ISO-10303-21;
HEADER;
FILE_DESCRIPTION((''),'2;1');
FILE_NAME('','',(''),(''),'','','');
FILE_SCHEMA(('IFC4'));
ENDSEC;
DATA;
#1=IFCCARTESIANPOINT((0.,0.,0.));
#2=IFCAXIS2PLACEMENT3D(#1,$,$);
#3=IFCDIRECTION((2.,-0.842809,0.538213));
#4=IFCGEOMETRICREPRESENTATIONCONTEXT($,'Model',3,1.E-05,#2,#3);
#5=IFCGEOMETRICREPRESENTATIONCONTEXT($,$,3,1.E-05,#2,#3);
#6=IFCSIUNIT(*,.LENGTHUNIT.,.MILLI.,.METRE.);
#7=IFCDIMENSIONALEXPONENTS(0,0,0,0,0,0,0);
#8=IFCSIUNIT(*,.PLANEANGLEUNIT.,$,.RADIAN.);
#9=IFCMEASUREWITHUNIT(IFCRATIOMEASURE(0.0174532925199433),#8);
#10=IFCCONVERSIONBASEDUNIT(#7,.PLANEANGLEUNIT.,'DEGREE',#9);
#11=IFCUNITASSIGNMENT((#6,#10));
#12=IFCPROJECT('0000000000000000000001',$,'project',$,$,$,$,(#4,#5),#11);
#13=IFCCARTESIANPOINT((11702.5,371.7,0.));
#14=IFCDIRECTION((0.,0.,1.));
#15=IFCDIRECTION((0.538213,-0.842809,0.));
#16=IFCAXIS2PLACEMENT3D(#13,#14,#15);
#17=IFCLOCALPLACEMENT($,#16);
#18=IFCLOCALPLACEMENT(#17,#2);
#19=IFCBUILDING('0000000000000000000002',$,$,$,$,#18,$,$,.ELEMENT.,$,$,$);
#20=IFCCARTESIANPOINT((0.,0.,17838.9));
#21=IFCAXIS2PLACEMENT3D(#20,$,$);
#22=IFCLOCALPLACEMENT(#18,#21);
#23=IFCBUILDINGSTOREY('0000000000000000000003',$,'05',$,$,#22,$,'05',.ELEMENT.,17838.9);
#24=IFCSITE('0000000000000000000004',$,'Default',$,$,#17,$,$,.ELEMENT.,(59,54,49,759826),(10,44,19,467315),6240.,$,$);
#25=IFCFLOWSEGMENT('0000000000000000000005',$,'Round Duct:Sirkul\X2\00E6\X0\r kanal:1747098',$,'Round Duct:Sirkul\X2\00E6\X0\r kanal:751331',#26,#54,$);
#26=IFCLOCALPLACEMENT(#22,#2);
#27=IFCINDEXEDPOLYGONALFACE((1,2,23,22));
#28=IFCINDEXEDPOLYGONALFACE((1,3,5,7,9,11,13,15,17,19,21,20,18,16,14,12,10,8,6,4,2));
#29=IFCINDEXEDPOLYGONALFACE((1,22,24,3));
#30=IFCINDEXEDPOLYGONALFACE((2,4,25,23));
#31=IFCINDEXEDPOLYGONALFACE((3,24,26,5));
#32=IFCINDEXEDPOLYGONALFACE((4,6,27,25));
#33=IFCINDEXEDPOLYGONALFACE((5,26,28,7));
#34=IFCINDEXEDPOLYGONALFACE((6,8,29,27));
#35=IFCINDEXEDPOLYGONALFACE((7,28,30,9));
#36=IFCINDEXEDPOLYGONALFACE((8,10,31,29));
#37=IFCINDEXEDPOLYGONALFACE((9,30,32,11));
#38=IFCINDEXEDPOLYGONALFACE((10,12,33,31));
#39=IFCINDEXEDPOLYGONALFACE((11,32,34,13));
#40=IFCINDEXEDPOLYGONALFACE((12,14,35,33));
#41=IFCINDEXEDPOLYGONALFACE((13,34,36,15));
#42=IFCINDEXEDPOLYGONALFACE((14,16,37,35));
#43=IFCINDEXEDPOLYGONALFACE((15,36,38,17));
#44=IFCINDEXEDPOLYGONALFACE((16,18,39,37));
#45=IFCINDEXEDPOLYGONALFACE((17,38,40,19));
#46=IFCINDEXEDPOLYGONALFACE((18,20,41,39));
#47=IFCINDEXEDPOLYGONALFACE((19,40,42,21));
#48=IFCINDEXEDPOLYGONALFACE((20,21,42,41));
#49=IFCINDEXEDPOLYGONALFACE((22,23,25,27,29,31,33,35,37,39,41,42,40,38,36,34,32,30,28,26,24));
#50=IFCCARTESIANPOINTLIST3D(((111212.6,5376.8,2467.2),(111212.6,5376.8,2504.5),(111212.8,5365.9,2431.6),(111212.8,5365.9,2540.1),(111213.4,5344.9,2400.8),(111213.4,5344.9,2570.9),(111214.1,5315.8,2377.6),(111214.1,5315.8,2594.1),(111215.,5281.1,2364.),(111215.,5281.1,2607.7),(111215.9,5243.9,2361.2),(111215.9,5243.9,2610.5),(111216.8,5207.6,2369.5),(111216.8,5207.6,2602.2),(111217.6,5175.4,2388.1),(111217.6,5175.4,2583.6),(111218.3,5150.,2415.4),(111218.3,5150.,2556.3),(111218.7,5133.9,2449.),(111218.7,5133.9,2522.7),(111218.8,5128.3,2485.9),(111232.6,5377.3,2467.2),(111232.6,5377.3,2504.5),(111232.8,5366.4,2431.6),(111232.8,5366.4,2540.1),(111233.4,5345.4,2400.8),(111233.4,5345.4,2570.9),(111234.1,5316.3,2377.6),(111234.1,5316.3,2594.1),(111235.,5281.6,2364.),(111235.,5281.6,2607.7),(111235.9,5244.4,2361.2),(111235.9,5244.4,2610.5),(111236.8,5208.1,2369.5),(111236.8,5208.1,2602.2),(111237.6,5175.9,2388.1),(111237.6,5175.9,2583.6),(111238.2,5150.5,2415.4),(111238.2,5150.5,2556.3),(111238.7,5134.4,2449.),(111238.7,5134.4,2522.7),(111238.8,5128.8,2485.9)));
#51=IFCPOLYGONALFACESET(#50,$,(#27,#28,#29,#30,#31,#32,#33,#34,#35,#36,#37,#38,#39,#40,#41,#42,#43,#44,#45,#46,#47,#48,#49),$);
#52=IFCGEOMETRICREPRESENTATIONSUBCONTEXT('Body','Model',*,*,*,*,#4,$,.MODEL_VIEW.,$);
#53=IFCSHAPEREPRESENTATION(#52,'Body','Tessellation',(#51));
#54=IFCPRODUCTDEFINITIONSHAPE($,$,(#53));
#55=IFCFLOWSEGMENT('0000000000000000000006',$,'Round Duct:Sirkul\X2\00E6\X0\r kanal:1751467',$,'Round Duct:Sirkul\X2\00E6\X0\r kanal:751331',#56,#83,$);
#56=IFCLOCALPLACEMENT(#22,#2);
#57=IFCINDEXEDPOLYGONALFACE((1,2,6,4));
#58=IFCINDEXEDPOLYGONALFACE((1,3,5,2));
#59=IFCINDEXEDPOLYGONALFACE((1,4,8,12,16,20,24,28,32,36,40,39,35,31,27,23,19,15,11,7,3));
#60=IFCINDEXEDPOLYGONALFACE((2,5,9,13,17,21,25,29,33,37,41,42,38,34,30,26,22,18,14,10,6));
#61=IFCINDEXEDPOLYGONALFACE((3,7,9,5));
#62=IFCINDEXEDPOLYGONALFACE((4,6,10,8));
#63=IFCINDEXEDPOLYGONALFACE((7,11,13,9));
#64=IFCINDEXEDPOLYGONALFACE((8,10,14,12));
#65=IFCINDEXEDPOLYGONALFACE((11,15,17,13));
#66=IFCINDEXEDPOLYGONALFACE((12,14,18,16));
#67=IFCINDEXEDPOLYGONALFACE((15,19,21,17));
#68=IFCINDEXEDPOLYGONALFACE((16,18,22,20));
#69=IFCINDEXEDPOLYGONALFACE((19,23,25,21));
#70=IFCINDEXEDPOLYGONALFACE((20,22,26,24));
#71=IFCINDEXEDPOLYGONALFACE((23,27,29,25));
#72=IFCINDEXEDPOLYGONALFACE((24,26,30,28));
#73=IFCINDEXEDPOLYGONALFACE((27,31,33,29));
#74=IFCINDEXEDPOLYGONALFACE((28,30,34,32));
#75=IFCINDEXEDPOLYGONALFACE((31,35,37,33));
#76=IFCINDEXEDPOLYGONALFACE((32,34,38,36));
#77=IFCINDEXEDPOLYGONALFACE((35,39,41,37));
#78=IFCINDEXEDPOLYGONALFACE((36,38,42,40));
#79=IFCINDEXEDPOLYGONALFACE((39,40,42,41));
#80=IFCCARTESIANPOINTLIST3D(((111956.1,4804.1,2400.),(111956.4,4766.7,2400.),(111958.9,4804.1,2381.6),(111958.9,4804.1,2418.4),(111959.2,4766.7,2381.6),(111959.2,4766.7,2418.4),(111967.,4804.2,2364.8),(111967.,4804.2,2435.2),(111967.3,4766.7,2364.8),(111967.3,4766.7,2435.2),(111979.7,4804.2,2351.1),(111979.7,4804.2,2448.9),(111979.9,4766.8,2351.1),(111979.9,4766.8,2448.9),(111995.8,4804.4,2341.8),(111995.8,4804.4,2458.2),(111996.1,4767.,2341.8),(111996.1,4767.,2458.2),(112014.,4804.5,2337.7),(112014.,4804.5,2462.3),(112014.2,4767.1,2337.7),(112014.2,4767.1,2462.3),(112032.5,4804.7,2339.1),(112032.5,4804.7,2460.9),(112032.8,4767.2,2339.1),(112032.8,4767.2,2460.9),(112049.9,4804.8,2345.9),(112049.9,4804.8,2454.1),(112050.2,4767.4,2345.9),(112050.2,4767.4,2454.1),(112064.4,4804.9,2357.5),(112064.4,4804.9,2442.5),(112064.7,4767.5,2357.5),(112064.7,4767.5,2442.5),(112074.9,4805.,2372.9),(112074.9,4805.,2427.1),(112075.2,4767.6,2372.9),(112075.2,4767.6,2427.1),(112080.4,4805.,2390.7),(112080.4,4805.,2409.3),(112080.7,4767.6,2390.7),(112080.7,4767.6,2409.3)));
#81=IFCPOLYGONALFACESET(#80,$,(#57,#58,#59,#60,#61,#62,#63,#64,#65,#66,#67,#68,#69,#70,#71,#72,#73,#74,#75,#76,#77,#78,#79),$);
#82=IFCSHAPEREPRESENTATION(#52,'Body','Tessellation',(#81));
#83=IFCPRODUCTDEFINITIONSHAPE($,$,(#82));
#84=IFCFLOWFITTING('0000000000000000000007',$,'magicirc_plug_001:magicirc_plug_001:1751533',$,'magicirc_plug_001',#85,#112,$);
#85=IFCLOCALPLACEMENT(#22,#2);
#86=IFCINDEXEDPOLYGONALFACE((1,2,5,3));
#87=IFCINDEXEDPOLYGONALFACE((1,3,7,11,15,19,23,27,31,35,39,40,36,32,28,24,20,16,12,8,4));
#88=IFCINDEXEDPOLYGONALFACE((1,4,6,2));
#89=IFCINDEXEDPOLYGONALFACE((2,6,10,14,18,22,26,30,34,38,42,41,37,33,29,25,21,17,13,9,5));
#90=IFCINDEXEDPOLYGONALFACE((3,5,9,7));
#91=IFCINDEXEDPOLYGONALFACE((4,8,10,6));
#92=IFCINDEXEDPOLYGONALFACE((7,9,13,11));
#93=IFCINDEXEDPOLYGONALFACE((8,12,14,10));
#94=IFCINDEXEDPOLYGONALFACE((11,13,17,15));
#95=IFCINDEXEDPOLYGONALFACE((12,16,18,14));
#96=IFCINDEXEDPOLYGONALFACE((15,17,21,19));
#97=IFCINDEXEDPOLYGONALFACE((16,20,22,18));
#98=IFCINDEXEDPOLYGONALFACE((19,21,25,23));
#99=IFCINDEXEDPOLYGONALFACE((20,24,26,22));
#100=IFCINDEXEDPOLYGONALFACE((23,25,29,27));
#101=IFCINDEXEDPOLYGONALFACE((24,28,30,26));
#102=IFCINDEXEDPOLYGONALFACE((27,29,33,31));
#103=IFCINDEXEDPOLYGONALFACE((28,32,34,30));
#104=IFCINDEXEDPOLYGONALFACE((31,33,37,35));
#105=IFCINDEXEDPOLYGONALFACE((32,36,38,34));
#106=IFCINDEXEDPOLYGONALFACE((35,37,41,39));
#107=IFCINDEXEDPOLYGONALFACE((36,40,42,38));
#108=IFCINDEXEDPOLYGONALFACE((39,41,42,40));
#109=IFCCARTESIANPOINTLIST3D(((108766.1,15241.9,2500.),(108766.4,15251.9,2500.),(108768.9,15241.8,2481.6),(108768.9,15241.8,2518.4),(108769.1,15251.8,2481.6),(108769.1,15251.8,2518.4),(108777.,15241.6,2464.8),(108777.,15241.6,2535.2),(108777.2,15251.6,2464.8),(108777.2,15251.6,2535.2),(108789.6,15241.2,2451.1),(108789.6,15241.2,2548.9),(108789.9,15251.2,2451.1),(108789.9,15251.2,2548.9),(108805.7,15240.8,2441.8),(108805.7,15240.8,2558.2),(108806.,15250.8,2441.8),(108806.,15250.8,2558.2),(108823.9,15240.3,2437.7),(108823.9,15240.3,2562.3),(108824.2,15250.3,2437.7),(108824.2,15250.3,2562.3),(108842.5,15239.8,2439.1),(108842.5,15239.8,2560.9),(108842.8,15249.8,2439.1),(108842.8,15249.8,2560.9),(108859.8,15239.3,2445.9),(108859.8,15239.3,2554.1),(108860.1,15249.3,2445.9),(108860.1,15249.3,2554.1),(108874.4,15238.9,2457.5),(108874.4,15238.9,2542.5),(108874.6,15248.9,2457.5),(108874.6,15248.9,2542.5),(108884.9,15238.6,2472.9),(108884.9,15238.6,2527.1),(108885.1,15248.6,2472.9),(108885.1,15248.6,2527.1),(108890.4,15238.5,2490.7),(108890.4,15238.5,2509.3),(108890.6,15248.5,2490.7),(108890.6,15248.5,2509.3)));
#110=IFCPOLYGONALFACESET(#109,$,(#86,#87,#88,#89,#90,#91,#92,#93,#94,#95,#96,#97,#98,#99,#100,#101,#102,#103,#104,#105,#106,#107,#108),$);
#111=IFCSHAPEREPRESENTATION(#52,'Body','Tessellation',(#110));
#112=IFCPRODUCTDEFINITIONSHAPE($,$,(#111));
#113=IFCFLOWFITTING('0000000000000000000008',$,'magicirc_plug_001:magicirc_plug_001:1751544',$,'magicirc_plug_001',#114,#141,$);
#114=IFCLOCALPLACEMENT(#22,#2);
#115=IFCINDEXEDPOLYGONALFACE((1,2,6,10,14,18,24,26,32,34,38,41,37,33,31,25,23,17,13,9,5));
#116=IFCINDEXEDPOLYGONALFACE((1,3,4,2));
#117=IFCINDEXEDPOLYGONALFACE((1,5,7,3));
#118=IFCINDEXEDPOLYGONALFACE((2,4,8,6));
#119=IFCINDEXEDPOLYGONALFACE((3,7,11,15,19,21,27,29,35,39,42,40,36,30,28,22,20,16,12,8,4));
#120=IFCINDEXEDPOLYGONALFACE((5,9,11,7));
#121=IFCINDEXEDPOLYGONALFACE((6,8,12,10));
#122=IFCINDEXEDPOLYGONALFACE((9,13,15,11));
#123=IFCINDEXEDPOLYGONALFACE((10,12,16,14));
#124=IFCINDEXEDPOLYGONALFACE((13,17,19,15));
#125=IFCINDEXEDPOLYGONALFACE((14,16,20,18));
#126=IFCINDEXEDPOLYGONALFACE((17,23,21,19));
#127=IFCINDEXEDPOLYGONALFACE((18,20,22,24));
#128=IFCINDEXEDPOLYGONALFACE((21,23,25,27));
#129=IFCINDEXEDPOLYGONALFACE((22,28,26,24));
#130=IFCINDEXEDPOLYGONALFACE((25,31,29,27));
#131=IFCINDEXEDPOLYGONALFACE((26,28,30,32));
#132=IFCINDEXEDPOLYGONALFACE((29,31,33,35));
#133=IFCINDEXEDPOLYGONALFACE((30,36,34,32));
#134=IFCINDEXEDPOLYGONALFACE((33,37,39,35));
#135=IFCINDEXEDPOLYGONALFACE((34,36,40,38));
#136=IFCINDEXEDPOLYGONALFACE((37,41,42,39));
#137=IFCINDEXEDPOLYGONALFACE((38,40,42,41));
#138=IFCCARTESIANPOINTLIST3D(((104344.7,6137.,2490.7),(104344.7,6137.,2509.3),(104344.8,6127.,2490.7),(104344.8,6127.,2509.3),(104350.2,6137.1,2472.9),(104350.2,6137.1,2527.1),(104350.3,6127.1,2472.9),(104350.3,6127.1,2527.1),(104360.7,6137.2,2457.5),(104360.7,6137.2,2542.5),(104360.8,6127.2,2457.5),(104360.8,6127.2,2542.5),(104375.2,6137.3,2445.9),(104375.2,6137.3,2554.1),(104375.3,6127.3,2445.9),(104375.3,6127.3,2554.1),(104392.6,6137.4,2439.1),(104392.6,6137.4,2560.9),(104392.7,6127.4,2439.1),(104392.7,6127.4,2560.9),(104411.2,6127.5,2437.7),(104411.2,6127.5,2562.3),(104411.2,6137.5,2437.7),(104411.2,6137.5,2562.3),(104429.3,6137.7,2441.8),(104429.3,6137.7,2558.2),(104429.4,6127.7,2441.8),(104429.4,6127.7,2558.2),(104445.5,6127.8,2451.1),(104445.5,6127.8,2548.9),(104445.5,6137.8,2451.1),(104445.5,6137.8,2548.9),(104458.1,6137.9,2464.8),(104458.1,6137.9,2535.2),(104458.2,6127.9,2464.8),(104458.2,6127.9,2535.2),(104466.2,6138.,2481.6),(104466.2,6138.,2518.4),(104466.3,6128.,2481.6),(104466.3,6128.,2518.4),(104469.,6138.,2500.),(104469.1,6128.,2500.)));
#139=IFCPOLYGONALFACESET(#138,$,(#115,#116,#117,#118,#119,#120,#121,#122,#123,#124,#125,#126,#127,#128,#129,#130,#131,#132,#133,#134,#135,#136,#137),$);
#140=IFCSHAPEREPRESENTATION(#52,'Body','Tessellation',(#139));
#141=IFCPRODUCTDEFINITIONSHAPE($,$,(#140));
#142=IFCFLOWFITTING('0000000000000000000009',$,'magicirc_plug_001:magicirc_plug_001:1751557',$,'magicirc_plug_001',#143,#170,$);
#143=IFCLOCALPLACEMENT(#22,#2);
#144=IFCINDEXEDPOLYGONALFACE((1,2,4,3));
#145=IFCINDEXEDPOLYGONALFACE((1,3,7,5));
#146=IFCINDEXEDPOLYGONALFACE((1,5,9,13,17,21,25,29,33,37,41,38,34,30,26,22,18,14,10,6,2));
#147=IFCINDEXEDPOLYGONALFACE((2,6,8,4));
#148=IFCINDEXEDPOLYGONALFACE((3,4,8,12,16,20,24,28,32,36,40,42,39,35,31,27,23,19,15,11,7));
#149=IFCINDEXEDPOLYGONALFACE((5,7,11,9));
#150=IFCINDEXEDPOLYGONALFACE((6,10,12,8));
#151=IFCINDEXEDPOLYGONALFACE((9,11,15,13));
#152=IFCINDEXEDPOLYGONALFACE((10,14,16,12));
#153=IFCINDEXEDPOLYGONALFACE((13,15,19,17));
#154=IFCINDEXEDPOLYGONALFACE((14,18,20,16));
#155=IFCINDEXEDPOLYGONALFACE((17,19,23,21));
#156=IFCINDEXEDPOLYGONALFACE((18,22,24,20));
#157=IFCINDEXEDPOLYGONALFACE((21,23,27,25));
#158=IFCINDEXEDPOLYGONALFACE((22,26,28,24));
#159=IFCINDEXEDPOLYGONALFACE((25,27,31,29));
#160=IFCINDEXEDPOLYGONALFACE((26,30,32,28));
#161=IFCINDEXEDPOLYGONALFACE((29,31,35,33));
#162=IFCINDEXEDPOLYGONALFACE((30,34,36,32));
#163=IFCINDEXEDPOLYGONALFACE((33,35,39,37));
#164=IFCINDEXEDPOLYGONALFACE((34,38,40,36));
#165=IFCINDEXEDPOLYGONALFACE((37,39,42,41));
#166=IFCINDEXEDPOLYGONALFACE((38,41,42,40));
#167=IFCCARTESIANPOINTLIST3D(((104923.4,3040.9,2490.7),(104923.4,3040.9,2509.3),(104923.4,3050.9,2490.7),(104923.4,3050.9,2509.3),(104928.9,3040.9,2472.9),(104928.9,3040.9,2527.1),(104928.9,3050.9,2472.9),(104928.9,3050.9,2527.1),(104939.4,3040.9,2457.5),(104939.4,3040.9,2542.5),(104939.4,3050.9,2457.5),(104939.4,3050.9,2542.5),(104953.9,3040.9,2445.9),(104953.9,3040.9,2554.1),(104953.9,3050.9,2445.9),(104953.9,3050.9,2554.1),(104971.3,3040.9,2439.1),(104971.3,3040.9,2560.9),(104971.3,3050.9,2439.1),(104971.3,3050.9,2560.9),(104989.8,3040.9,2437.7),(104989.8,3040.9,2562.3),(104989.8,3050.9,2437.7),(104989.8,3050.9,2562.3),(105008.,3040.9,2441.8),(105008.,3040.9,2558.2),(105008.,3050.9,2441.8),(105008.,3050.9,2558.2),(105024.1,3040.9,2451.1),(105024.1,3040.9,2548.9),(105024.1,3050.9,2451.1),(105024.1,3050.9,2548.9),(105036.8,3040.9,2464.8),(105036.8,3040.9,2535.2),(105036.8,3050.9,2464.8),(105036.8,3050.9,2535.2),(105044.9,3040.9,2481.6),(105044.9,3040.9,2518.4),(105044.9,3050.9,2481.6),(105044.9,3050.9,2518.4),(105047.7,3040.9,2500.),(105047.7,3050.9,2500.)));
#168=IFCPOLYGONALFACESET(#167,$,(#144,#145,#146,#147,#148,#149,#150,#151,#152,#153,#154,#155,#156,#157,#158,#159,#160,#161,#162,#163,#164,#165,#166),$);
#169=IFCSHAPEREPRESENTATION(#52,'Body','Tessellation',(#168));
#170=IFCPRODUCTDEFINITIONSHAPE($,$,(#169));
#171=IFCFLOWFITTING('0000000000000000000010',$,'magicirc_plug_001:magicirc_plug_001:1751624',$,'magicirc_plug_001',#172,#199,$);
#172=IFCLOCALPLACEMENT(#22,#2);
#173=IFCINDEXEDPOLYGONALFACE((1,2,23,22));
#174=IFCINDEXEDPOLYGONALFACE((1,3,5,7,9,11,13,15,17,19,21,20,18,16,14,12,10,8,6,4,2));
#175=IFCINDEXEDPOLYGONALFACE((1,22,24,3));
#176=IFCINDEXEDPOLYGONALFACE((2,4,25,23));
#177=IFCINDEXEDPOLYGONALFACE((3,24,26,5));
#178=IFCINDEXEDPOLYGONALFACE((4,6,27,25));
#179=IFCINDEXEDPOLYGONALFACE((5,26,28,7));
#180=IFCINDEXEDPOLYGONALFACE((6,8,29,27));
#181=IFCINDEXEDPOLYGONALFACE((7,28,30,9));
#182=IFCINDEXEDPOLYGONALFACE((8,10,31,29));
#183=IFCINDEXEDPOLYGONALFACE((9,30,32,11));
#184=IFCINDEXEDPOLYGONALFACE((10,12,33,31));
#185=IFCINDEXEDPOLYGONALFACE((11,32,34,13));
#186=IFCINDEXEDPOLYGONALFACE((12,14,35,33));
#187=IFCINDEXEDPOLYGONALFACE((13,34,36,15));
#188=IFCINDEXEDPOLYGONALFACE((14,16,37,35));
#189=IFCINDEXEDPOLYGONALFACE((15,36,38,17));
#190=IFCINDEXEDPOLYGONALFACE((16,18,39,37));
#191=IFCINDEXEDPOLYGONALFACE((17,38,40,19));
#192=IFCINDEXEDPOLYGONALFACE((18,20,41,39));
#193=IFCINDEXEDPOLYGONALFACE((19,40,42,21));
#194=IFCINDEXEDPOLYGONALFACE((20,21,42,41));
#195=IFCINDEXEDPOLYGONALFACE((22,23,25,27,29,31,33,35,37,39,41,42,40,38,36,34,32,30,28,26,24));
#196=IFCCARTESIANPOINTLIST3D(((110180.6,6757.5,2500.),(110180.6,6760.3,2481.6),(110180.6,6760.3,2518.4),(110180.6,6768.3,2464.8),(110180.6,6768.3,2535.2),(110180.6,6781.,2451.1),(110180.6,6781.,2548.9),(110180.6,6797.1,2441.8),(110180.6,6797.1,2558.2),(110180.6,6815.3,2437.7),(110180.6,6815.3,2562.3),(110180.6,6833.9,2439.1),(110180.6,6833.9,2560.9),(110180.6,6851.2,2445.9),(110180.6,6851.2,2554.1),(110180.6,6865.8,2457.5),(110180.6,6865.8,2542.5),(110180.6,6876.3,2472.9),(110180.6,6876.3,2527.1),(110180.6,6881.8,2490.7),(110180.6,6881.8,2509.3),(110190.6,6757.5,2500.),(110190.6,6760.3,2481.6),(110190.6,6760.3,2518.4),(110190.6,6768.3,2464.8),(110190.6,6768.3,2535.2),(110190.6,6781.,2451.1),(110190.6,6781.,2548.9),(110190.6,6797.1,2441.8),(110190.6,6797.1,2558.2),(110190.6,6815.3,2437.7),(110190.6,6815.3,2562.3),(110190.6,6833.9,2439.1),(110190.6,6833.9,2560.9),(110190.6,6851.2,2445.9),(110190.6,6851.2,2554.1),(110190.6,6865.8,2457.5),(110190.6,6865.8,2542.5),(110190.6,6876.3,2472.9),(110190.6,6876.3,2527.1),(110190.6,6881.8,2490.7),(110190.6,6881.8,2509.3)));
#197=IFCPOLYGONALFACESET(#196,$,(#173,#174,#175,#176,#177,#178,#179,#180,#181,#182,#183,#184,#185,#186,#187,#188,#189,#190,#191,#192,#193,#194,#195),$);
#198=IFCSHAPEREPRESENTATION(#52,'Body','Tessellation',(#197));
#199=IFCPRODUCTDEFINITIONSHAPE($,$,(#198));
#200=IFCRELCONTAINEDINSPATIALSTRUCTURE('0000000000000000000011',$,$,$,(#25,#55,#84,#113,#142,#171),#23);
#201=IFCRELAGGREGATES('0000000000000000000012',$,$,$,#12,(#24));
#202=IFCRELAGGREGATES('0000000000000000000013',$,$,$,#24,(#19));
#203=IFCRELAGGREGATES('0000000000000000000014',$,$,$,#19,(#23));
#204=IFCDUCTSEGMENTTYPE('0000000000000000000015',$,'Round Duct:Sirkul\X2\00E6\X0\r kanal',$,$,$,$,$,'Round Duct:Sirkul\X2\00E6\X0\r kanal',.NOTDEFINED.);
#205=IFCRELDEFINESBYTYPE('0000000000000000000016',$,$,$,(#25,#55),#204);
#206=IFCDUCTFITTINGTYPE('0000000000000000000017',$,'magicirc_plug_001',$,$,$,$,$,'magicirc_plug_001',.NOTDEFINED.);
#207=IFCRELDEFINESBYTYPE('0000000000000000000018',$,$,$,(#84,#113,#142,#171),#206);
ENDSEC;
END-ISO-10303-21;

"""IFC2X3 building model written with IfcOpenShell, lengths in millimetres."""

from ifc_helpers import new_model, entity, si_unit, converted_unit, direction, frame, frame_2d, origin, place, context, subcontext, project, spatial, circle, extrude, source, transform, mapped, type_object, type_shapes, element, save


model = new_model("IFC2X3")

# Units and contexts
model_context = context("Model", 3, precision=1e-05, world=origin(), true_north=direction((2.0, -0.842809, 0.538213)))
context_of_model = context(None, 3, precision=1e-05, world=origin(), true_north=direction((2.0, -0.842809, 0.538213)))
body_context = subcontext(model_context, "Body", "Model", "MODEL_VIEW")
ifc_project = project(units=[si_unit("LENGTHUNIT", "METRE", prefix="MILLI"), converted_unit("PLANEANGLEUNIT", "DEGREE", entity("IfcRatioMeasure", 0.0174532925199433), si_unit("PLANEANGLEUNIT", "RADIAN"), dimensions=[0, 0, 0, 0, 0, 0, 0])], contexts=[model_context, context_of_model])

# Site, building, storey
site_placement = place(None, frame((11702.5, 371.7, 0.0), z_axis=(0.0, 0.0, 1.0), x_axis=(0.538213, -0.842809, 0.0)))
site = spatial("IfcSite", under=ifc_project, at=site_placement, Name="Default", CompositionType="ELEMENT", RefLatitude=(59, 54, 49, 759826), RefLongitude=(10, 44, 19, 467315), RefElevation=6240.0)
building_placement = place(site_placement, origin())
building = spatial("IfcBuilding", under=site, at=building_placement, CompositionType="ELEMENT")
storey_placement = place(building_placement, frame((0.0, 0.0, 17838.9)))
storey = spatial("IfcBuildingStorey", under=building, at=storey_placement, Name="05", LongName="05", CompositionType="ELEMENT", Elevation=17838.9)

# Flow segments
duct_segment_type = type_object("IfcDuctSegmentType", Name="Round Duct:Sirkulær kanal", ElementType="Round Duct:Sirkulær kanal", PredefinedType="NOTDEFINED")
flow_segment_1_placement = place(storey_placement, origin())
element("IfcFlowSegment", 1, at=flow_segment_1_placement, inside=storey, type_object=duct_segment_type, Name="Round Duct:Sirkulær kanal:1747098", ObjectType="Round Duct:Sirkulær kanal:751331", context=body_context, shape_type="SweptSolid", body=[
    extrude(circle(Radius=125.0, at=frame_2d((0.0, 0.0), x_axis=(1.0, 0.0))), frame((111215.7, 5253.3, 2485.9), z_axis=(0.999685, 0.025094, 0.0), x_axis=(0.025094, -0.999685, 0.0)), (0.0, 0.0, 1.0), 20.0),
])
flow_segment_2_placement = place(storey_placement, origin())
element("IfcFlowSegment", 2, at=flow_segment_2_placement, inside=storey, type_object=duct_segment_type, Name="Round Duct:Sirkulær kanal:1751467", ObjectType="Round Duct:Sirkulær kanal:751331", context=body_context, shape_type="SweptSolid", body=[
    extrude(circle(Radius=62.5, at=frame_2d((0.0, 0.0), x_axis=(1.0, 0.0))), frame((112018.6, 4804.5, 2400.0), z_axis=(0.007643, -0.999971, 0.0), x_axis=(-0.999971, -0.007643, 0.0)), (0.0, 0.0, 1.0), 37.4),
])

# Flow fittings
duct_fitting_type_1 = type_object("IfcDuctFittingType", Name="magicirc_plug_001", ElementType="magicirc_plug_001", PredefinedType="NOTDEFINED")
shared_shape_1 = source(origin(), body_context, "Body", "SweptSolid", [
    extrude(circle(Radius=62.5, at=frame_2d((0.0, 0.0), x_axis=(1.0, 0.0))), frame((0.0, 0.0, 0.0), z_axis=(1.0, 0.0, 0.0), x_axis=(0.0, 1.0, 0.0)), (0.0, 0.0, 1.0), 10.0),
])
type_shapes(duct_fitting_type_1, [shared_shape_1])
for number, where, z_axis, x_axis, name in (
    (3, (108828.6, 15240.2, 2500.0), (0.0, 0.0, 1.0), (0.02726, 0.999628, 0.0), "magicirc_plug_001:magicirc_plug_001:1751533"),
    (4, (104406.5, 6137.5, 2500.0), (0.0, 0.0, 1.0), (0.007643, -0.999971, 0.0), "magicirc_plug_001:magicirc_plug_001:1751544"),
    (5, (104985.2, 3050.9, 2500.0), (0.0, 0.0, 1.0), (0.0, -1.0, 0.0), "magicirc_plug_001:magicirc_plug_001:1751557"),
    (6, (110190.6, 6820.0, 2500.0), (0.0, 0.0, 1.0), (-1.0, 0.0, 0.0), "magicirc_plug_001:magicirc_plug_001:1751624"),
):
    element("IfcFlowFitting", number, at=place(storey_placement, frame(where, z_axis=z_axis, x_axis=x_axis)), inside=storey, type_object=duct_fitting_type_1, Name=name, ObjectType="magicirc_plug_001", context=body_context, shape_type="MappedRepresentation", body=[
        mapped(shared_shape_1, transform((0.0, 0.0, 0.0), scale=1.0)),
    ])

save(model, "model.ifc")
